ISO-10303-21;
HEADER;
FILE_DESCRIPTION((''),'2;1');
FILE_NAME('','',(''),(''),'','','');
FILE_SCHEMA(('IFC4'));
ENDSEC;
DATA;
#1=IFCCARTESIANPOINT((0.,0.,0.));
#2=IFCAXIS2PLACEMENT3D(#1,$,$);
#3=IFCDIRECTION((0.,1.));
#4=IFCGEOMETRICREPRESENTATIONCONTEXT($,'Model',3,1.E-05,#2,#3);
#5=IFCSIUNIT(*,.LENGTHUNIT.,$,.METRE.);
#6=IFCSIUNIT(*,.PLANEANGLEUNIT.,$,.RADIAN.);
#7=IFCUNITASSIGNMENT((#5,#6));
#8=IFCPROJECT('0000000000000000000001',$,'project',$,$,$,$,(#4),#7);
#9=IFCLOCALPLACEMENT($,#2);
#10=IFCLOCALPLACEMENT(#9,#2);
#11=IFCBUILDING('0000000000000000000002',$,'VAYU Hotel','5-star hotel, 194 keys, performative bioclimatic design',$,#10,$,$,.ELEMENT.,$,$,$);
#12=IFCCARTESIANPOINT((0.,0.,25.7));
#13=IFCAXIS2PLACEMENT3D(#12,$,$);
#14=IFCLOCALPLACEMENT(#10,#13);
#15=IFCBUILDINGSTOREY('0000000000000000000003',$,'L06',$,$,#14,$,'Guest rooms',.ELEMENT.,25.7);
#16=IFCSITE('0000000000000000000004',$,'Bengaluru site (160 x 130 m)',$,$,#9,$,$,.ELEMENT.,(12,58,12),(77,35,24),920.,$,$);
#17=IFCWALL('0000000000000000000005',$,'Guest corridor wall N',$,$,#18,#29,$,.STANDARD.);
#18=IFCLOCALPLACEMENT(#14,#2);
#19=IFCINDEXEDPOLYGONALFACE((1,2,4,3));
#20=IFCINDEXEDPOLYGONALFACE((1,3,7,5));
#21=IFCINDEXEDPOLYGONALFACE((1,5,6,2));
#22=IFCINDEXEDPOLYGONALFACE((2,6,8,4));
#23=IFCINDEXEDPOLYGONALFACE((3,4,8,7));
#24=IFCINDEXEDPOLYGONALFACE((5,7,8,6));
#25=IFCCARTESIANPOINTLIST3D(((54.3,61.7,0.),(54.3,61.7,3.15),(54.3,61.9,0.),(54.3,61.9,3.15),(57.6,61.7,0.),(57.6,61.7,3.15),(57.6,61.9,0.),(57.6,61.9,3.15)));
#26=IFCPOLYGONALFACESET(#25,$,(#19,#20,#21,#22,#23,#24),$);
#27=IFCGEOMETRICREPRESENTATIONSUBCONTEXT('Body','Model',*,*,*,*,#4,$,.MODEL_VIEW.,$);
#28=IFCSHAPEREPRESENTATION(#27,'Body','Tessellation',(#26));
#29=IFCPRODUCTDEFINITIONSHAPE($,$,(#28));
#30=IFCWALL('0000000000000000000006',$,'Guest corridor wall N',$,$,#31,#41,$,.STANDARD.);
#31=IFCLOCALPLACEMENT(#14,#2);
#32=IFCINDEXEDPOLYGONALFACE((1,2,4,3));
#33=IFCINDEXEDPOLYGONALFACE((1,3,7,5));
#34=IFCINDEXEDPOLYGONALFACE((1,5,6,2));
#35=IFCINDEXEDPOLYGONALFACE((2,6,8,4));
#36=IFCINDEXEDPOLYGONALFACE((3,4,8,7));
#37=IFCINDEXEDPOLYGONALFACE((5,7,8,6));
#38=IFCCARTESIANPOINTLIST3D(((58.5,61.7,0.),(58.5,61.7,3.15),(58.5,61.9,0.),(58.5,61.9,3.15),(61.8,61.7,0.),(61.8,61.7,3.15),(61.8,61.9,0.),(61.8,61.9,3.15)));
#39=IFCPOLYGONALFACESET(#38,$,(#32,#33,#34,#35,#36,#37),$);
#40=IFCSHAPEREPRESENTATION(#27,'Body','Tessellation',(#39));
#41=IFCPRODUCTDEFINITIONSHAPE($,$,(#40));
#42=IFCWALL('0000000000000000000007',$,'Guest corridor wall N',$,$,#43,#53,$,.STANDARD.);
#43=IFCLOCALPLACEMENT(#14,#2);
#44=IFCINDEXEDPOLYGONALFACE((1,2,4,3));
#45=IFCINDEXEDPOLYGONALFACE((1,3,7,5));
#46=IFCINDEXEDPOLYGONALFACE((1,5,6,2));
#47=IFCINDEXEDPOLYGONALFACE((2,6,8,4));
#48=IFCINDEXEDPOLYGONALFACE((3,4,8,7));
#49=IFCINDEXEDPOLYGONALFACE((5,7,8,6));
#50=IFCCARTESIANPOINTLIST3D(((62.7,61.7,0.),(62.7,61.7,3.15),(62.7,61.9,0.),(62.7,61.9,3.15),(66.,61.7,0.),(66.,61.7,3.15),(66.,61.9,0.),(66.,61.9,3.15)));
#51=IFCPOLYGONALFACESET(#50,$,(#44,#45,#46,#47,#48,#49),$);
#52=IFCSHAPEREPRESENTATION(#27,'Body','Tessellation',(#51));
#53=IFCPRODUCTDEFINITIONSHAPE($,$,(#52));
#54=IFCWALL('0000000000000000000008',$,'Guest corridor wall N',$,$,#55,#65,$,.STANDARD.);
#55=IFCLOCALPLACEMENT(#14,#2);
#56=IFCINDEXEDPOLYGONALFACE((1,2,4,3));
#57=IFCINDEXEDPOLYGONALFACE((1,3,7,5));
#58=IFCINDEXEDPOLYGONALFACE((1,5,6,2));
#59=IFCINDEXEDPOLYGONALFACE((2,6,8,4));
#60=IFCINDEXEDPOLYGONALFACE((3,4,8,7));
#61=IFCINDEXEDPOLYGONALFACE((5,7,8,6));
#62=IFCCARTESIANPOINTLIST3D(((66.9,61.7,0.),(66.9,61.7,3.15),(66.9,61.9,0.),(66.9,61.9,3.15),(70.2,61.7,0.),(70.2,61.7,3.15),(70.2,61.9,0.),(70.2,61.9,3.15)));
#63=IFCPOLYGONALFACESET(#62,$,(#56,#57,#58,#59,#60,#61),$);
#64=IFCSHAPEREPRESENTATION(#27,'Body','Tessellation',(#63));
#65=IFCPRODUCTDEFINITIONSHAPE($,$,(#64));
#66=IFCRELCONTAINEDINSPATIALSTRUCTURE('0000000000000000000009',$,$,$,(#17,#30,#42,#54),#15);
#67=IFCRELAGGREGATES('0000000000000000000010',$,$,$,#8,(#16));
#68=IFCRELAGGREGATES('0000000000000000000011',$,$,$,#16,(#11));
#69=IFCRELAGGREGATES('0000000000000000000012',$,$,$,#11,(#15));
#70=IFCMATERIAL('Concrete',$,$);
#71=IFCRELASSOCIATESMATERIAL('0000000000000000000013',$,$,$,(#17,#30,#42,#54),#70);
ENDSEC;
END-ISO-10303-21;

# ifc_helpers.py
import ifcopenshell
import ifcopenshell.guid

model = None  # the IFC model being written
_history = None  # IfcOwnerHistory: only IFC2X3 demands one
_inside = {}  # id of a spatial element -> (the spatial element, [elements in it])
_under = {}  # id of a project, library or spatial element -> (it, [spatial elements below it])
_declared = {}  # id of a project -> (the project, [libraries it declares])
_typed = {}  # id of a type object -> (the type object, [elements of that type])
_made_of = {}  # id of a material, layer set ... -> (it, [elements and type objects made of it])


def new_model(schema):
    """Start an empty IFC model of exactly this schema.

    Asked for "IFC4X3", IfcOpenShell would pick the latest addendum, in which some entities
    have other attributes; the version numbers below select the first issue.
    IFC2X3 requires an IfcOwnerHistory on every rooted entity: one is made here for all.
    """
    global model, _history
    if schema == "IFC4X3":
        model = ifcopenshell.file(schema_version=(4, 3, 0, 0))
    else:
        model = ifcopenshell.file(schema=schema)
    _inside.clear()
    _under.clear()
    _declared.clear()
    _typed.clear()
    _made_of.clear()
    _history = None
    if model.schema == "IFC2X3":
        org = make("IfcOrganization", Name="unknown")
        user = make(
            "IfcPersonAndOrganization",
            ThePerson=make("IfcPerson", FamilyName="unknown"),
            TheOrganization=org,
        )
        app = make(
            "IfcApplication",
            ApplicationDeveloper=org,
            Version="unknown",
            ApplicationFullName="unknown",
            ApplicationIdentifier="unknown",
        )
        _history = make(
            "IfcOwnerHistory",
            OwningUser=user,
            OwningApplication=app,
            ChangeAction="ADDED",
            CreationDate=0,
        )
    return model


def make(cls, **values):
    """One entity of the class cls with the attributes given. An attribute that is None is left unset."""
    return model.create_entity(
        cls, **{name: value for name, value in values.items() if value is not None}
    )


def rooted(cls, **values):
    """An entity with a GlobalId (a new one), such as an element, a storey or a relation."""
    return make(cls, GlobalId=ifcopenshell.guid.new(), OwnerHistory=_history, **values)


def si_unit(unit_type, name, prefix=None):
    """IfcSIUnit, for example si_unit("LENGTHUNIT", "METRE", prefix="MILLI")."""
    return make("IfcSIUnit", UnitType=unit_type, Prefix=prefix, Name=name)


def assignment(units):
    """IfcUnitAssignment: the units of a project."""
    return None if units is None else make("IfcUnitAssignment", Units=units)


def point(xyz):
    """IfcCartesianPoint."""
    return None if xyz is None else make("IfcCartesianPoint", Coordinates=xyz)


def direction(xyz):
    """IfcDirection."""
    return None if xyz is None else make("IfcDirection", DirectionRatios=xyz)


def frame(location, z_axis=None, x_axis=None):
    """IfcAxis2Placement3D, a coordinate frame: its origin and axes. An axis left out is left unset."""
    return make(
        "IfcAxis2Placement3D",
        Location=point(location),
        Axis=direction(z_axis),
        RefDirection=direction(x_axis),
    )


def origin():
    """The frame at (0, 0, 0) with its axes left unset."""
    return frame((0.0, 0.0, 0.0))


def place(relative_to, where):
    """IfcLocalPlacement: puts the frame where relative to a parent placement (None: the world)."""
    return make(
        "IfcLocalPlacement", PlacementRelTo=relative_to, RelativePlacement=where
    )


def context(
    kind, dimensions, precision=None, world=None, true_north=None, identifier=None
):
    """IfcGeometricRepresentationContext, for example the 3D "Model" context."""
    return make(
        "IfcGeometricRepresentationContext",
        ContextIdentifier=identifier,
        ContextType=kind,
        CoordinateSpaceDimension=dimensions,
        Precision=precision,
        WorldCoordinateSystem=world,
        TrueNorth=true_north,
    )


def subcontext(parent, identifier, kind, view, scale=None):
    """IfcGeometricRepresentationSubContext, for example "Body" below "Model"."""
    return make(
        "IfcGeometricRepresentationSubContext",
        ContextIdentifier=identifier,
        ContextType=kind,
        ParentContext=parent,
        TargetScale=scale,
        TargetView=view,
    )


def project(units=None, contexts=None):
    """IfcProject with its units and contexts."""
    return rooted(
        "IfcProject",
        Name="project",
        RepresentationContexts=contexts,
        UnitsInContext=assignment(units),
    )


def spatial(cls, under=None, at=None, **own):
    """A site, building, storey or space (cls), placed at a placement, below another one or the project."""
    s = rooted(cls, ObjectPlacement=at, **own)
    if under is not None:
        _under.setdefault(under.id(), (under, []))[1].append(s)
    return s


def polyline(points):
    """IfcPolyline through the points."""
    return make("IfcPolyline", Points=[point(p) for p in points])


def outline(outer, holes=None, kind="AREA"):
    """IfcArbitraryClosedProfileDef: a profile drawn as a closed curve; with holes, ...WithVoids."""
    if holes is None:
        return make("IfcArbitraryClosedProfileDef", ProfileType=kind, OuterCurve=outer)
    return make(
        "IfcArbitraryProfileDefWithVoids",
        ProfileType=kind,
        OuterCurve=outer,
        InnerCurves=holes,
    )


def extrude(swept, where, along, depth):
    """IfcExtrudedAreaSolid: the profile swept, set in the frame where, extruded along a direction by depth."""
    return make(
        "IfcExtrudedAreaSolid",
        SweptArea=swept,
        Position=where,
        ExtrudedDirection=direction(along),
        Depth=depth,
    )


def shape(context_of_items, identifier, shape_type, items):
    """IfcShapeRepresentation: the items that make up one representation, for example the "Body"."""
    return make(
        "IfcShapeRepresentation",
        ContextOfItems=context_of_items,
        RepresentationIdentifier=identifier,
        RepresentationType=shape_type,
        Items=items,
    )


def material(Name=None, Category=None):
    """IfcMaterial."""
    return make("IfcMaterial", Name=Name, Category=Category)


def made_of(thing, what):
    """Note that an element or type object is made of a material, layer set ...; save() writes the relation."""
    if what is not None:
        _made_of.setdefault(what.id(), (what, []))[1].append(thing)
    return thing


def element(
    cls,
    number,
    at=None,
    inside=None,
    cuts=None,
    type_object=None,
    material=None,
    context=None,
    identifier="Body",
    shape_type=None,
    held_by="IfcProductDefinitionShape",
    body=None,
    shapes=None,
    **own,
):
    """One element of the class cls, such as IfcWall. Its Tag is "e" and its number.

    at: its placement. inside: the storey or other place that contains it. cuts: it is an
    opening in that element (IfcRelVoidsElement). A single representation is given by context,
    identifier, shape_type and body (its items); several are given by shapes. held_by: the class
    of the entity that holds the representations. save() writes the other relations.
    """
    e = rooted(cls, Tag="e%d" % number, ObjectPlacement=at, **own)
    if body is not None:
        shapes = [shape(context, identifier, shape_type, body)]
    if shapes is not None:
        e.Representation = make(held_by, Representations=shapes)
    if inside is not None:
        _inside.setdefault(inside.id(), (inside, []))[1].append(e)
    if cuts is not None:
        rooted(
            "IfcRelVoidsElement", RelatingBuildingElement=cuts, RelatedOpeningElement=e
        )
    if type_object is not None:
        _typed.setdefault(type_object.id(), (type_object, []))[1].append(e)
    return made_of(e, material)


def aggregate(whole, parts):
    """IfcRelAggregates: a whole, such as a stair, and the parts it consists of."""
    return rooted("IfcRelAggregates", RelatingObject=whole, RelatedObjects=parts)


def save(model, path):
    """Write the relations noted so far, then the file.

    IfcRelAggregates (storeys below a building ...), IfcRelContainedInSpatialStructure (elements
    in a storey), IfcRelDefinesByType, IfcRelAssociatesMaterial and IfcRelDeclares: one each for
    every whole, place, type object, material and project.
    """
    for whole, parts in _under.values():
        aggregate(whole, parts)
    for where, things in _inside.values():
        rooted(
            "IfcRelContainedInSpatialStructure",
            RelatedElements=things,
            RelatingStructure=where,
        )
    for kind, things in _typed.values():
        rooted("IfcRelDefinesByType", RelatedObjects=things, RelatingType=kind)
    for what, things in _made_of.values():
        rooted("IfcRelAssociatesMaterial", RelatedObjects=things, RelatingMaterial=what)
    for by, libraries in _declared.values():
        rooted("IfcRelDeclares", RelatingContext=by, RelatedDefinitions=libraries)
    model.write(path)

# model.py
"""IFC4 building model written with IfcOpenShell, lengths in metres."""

from ifc_helpers import new_model, si_unit, direction, frame, origin, place, context, subcontext, project, spatial, polyline, outline, extrude, material, element, save


model = new_model("IFC4")

# Units and contexts
model_context = context("Model", 3, precision=1e-05, world=origin(), true_north=direction((0.0, 1.0)))
body_context = subcontext(model_context, "Body", "Model", "MODEL_VIEW")
ifc_project = project(units=[si_unit("LENGTHUNIT", "METRE"), si_unit("PLANEANGLEUNIT", "RADIAN")], contexts=[model_context])

# Site, building, storey
site_placement = place(None, origin())
site = spatial("IfcSite", under=ifc_project, at=site_placement, Name="Bengaluru site (160 x 130 m)", CompositionType="ELEMENT", RefLatitude=(12, 58, 12), RefLongitude=(77, 35, 24), RefElevation=920.0)
building_placement = place(site_placement, origin())
building = spatial("IfcBuilding", under=site, at=building_placement, Name="VAYU Hotel", Description="5-star hotel, 194 keys, performative bioclimatic design", CompositionType="ELEMENT")
storey_placement = place(building_placement, frame((0.0, 0.0, 25.7)))
storey = spatial("IfcBuildingStorey", under=building, at=storey_placement, Name="L06", LongName="Guest rooms", CompositionType="ELEMENT", Elevation=25.7)

# Shared definitions
ifc_material = material(Name="Concrete")

# Walls
wall_1_placement = place(storey_placement, origin())
element("IfcWall", 1, at=wall_1_placement, inside=storey, material=ifc_material, Name="Guest corridor wall N", PredefinedType="STANDARD", context=body_context, shape_type="SweptSolid", body=[
    extrude(outline(polyline([(54.3, 61.9), (57.6, 61.9), (57.6, 61.7), (54.3, 61.7), (54.3, 61.9)])), origin(), (0.0, 0.0, 1.0), 3.15),
])
wall_2_placement = place(storey_placement, origin())
element("IfcWall", 2, at=wall_2_placement, inside=storey, material=ifc_material, Name="Guest corridor wall N", PredefinedType="STANDARD", context=body_context, shape_type="SweptSolid", body=[
    extrude(outline(polyline([(58.5, 61.9), (61.8, 61.9), (61.8, 61.7), (58.5, 61.7), (58.5, 61.9)])), origin(), (0.0, 0.0, 1.0), 3.15),
])
wall_3_placement = place(storey_placement, origin())
element("IfcWall", 3, at=wall_3_placement, inside=storey, material=ifc_material, Name="Guest corridor wall N", PredefinedType="STANDARD", context=body_context, shape_type="SweptSolid", body=[
    extrude(outline(polyline([(62.7, 61.9), (66.0, 61.9), (66.0, 61.7), (62.7, 61.7), (62.7, 61.9)])), origin(), (0.0, 0.0, 1.0), 3.15),
])
wall_4_placement = place(storey_placement, origin())
element("IfcWall", 4, at=wall_4_placement, inside=storey, material=ifc_material, Name="Guest corridor wall N", PredefinedType="STANDARD", context=body_context, shape_type="SweptSolid", body=[
    extrude(outline(polyline([(66.9, 61.9), (70.2, 61.9), (70.2, 61.7), (66.9, 61.7), (66.9, 61.9)])), origin(), (0.0, 0.0, 1.0), 3.15),
])

save(model, "model.ifc")
